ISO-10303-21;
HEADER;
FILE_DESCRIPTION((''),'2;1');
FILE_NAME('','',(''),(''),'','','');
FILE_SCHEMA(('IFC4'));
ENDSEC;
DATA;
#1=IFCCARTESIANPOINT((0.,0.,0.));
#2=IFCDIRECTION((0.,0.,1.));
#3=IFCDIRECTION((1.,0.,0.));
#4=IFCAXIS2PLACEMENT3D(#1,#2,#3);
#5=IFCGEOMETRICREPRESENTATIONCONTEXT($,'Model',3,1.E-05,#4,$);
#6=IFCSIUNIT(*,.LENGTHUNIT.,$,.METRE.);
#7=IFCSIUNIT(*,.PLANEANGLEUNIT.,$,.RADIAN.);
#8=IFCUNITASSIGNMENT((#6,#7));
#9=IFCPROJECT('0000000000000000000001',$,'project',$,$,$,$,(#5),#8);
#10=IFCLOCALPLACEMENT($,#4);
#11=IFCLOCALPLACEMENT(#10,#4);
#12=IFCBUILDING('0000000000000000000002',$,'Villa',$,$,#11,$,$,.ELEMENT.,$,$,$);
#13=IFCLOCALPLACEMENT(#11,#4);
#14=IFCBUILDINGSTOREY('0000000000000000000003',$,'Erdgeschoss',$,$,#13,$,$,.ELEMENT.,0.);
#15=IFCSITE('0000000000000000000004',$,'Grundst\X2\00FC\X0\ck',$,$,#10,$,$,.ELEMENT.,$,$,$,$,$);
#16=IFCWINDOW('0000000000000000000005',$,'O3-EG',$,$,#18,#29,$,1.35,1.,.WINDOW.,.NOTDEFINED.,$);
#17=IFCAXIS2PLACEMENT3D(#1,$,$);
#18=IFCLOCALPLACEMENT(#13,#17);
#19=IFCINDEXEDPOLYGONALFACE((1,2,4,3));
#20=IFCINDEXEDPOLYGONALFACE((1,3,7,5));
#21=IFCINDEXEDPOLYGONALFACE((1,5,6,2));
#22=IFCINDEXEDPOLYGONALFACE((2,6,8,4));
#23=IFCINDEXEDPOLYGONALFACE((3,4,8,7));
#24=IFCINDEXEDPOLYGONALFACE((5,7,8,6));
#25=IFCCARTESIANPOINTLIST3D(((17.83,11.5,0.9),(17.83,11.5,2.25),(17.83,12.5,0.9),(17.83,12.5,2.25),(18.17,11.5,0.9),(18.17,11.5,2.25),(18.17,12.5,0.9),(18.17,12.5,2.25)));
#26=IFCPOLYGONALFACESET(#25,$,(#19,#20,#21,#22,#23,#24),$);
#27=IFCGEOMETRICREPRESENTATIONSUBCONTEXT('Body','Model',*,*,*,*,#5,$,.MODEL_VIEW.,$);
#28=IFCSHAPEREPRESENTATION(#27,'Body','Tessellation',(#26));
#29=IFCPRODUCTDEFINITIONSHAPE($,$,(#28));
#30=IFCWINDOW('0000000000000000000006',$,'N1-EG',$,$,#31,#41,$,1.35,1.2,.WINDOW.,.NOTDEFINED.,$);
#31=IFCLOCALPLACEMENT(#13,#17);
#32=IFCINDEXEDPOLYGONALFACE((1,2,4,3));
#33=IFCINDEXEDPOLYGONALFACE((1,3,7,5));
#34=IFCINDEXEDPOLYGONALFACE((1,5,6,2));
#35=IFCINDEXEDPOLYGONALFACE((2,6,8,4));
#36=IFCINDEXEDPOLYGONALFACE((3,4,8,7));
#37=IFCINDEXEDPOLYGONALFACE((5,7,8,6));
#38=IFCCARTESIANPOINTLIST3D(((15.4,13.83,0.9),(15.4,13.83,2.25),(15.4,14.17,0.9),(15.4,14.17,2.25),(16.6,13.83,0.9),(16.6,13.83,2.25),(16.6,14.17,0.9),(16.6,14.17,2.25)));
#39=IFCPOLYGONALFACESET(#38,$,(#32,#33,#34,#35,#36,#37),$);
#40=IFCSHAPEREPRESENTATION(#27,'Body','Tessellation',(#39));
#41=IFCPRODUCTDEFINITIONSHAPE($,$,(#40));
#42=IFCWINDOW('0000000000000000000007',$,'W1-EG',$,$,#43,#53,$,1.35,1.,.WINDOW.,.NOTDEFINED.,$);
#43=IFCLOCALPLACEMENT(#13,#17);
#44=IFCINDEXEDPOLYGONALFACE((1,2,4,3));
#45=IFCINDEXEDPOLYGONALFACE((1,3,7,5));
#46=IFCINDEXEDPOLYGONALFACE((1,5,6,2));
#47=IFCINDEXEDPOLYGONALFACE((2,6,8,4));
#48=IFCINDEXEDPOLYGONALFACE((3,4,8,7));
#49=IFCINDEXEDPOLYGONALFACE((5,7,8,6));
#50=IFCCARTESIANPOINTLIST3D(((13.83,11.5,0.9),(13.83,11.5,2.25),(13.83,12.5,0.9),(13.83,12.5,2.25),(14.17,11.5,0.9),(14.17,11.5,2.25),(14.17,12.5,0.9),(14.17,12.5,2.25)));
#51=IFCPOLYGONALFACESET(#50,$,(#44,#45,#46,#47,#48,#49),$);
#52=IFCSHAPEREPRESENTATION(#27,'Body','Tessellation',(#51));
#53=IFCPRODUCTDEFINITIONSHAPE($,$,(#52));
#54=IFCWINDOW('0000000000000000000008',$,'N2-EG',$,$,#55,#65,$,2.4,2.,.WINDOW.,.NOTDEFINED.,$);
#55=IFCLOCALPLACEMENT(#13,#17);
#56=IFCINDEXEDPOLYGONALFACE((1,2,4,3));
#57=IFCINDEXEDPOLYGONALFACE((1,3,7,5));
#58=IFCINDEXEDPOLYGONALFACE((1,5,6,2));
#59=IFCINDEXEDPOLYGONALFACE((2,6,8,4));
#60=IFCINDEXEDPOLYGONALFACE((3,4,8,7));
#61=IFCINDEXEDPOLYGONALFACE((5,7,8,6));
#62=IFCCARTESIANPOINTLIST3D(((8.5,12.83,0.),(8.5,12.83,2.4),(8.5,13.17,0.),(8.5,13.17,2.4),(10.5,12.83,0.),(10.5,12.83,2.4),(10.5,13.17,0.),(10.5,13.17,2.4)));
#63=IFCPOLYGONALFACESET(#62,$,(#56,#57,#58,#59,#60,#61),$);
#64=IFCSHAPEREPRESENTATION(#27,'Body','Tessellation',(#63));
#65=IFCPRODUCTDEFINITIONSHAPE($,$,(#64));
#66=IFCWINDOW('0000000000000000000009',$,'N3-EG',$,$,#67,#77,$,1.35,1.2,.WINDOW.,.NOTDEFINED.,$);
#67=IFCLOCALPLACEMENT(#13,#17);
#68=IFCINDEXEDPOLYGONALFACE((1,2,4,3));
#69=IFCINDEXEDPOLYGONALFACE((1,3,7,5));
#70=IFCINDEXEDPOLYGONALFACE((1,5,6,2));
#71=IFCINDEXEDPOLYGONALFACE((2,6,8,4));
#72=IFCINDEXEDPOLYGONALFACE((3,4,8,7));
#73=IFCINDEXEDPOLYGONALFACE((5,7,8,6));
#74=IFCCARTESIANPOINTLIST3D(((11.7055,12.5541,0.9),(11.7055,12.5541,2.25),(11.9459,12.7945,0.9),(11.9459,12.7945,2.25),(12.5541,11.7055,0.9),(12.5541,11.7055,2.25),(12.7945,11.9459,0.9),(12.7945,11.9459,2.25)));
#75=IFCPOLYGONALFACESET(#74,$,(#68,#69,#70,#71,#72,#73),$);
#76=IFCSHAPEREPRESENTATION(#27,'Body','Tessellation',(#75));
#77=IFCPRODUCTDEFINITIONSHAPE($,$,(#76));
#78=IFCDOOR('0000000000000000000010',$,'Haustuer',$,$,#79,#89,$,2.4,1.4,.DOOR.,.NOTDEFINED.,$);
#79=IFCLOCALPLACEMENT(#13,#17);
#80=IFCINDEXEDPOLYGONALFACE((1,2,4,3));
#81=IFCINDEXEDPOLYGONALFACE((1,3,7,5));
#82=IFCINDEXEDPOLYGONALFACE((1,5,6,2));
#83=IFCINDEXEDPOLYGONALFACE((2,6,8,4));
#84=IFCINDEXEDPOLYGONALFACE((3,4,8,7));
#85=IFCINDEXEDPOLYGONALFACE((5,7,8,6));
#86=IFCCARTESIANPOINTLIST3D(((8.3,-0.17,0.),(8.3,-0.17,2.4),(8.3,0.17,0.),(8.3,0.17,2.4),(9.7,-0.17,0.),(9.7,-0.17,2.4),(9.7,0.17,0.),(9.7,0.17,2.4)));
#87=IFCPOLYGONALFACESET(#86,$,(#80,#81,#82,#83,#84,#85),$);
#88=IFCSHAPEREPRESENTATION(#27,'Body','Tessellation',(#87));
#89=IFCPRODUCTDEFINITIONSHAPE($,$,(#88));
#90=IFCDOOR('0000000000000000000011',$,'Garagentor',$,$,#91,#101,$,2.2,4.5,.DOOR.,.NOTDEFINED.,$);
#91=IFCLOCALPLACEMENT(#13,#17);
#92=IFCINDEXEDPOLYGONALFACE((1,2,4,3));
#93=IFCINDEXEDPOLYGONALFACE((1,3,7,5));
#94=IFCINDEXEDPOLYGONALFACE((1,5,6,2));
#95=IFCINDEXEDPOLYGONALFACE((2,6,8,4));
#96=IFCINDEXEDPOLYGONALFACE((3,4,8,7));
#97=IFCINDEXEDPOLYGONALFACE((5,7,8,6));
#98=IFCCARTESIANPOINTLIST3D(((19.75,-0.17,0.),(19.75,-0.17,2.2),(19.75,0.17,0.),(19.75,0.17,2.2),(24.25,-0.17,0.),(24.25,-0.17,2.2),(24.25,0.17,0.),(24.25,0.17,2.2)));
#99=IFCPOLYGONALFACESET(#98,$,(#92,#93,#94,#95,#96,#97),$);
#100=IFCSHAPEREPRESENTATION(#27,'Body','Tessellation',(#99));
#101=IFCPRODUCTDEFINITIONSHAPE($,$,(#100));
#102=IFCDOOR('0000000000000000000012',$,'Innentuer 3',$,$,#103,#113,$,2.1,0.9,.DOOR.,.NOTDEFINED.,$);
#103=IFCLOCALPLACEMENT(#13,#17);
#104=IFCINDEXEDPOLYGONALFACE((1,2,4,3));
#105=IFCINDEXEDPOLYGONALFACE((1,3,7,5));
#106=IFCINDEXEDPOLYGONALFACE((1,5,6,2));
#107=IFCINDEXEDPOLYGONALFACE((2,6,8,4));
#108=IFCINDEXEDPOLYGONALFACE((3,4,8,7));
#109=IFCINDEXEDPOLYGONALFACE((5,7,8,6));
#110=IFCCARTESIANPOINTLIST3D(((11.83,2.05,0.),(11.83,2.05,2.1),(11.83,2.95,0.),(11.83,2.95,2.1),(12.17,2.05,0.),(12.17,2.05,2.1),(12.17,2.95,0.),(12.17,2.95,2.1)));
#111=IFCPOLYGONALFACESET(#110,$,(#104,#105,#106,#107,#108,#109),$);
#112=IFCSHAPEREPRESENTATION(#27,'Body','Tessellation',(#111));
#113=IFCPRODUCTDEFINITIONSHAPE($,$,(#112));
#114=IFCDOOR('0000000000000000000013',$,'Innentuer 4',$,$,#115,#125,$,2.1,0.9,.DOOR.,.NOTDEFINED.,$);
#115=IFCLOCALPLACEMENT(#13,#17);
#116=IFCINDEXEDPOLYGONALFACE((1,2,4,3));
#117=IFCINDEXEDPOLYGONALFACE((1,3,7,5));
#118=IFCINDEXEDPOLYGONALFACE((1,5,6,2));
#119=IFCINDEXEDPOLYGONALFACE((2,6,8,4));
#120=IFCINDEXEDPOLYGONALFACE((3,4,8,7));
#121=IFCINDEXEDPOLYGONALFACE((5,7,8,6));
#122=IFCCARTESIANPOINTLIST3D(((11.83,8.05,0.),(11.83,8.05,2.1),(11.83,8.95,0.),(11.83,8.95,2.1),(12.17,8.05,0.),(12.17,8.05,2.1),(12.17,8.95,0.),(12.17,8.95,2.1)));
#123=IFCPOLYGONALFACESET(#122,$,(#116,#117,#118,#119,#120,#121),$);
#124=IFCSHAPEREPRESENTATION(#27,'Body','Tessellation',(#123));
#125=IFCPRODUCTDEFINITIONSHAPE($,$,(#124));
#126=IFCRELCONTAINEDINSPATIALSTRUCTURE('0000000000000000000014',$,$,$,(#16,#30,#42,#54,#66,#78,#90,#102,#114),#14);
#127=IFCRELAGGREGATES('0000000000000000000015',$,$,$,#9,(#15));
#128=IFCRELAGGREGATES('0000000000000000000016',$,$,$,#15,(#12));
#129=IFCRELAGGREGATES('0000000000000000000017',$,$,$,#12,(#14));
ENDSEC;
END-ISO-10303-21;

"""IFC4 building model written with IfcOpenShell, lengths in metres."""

from ifc_helpers import new_model, si_unit, frame, origin_with_axes, origin_2d, place, context, subcontext, project, spatial, rectangle, extrude, element, save


model = new_model("IFC4")

# Units and contexts
model_context = context("Model", 3, precision=1e-05, world=origin_with_axes())
body_context = subcontext(model_context, "Body", "Model", "MODEL_VIEW")
ifc_project = project(units=[si_unit("LENGTHUNIT", "METRE"), si_unit("PLANEANGLEUNIT", "RADIAN")], contexts=[model_context])

# Site, building, storey
site_placement = place(None, origin_with_axes())
site = spatial("IfcSite", under=ifc_project, at=site_placement, Name="Grundstück", CompositionType="ELEMENT")
building_placement = place(site_placement, origin_with_axes())
building = spatial("IfcBuilding", under=site, at=building_placement, Name="Villa", CompositionType="ELEMENT")
storey_placement = place(building_placement, origin_with_axes())
storey = spatial("IfcBuildingStorey", under=building, at=storey_placement, Name="Erdgeschoss", CompositionType="ELEMENT", Elevation=0.0)

# Windows
window_1_placement = place(storey_placement, frame((18.0, 12.0, 0.9), z_axis=(0.0, 0.0, 1.0), x_axis=(0.0, 1.0, 0.0)))
element("IfcWindow", 1, at=window_1_placement, inside=storey, Name="O3-EG", OverallHeight=1.35, OverallWidth=1.0, PartitioningType="NOTDEFINED", PredefinedType="WINDOW", context=body_context, shape_type="SweptSolid", body=[
    extrude(rectangle(XDim=1.0, YDim=0.34, at=origin_2d()), origin_with_axes(), (0.0, 0.0, 1.0), 1.35),
])
window_2_placement = place(storey_placement, frame((16.0, 14.0, 0.9), z_axis=(0.0, 0.0, 1.0), x_axis=(1.0, 0.0, 0.0)))
element("IfcWindow", 2, at=window_2_placement, inside=storey, Name="N1-EG", OverallHeight=1.35, OverallWidth=1.2, PartitioningType="NOTDEFINED", PredefinedType="WINDOW", context=body_context, shape_type="SweptSolid", body=[
    extrude(rectangle(XDim=1.2, YDim=0.34, at=origin_2d()), origin_with_axes(), (0.0, 0.0, 1.0), 1.35),
])
window_3_placement = place(storey_placement, frame((14.0, 12.0, 0.9), z_axis=(0.0, 0.0, 1.0), x_axis=(0.0, 1.0, 0.0)))
element("IfcWindow", 3, at=window_3_placement, inside=storey, Name="W1-EG", OverallHeight=1.35, OverallWidth=1.0, PartitioningType="NOTDEFINED", PredefinedType="WINDOW", context=body_context, shape_type="SweptSolid", body=[
    extrude(rectangle(XDim=1.0, YDim=0.34, at=origin_2d()), origin_with_axes(), (0.0, 0.0, 1.0), 1.35),
])
window_4_placement = place(storey_placement, frame((9.5, 13.0, 0.0), z_axis=(0.0, 0.0, 1.0), x_axis=(1.0, 0.0, 0.0)))
element("IfcWindow", 4, at=window_4_placement, inside=storey, Name="N2-EG", OverallHeight=2.4, OverallWidth=2.0, PartitioningType="NOTDEFINED", PredefinedType="WINDOW", context=body_context, shape_type="SweptSolid", body=[
    extrude(rectangle(XDim=2.0, YDim=0.34, at=origin_2d()), origin_with_axes(), (0.0, 0.0, 1.0), 2.4),
])
window_5_placement = place(storey_placement, frame((12.25, 12.25, 0.9), z_axis=(0.0, 0.0, 1.0), x_axis=(-0.7071, 0.7071, 0.0)))
element("IfcWindow", 5, at=window_5_placement, inside=storey, Name="N3-EG", OverallHeight=1.35, OverallWidth=1.2, PartitioningType="NOTDEFINED", PredefinedType="WINDOW", context=body_context, shape_type="SweptSolid", body=[
    extrude(rectangle(XDim=1.2, YDim=0.34, at=origin_2d()), origin_with_axes(), (0.0, 0.0, 1.0), 1.35),
])

# Doors
door_1_placement = place(storey_placement, frame((9.0, 0.0, 0.0), z_axis=(0.0, 0.0, 1.0), x_axis=(1.0, 0.0, 0.0)))
element("IfcDoor", 6, at=door_1_placement, inside=storey, Name="Haustuer", OperationType="NOTDEFINED", OverallHeight=2.4, OverallWidth=1.4, PredefinedType="DOOR", context=body_context, shape_type="SweptSolid", body=[
    extrude(rectangle(XDim=1.4, YDim=0.34, at=origin_2d()), origin_with_axes(), (0.0, 0.0, 1.0), 2.4),
])
door_2_placement = place(storey_placement, frame((22.0, 0.0, 0.0), z_axis=(0.0, 0.0, 1.0), x_axis=(1.0, 0.0, 0.0)))
element("IfcDoor", 7, at=door_2_placement, inside=storey, Name="Garagentor", OperationType="NOTDEFINED", OverallHeight=2.2, OverallWidth=4.5, PredefinedType="DOOR", context=body_context, shape_type="SweptSolid", body=[
    extrude(rectangle(XDim=4.5, YDim=0.34, at=origin_2d()), origin_with_axes(), (0.0, 0.0, 1.0), 2.2),
])
for number, where, z_axis, x_axis, name in (
    (8, (12.0, 2.5, 0.0), (0.0, 0.0, 1.0), (0.0, 1.0, 0.0), "Innentuer 3"),
    (9, (12.0, 8.5, 0.0), (0.0, 0.0, 1.0), (0.0, 1.0, 0.0), "Innentuer 4"),
):
    element("IfcDoor", number, at=place(storey_placement, frame(where, z_axis=z_axis, x_axis=x_axis)), inside=storey, Name=name, OperationType="NOTDEFINED", OverallHeight=2.1, OverallWidth=0.9, PredefinedType="DOOR", context=body_context, shape_type="SweptSolid", body=[
        extrude(rectangle(XDim=0.9, YDim=0.34, at=origin_2d()), origin_with_axes(), (0.0, 0.0, 1.0), 2.1),
    ])

save(model, "model.ifc")
